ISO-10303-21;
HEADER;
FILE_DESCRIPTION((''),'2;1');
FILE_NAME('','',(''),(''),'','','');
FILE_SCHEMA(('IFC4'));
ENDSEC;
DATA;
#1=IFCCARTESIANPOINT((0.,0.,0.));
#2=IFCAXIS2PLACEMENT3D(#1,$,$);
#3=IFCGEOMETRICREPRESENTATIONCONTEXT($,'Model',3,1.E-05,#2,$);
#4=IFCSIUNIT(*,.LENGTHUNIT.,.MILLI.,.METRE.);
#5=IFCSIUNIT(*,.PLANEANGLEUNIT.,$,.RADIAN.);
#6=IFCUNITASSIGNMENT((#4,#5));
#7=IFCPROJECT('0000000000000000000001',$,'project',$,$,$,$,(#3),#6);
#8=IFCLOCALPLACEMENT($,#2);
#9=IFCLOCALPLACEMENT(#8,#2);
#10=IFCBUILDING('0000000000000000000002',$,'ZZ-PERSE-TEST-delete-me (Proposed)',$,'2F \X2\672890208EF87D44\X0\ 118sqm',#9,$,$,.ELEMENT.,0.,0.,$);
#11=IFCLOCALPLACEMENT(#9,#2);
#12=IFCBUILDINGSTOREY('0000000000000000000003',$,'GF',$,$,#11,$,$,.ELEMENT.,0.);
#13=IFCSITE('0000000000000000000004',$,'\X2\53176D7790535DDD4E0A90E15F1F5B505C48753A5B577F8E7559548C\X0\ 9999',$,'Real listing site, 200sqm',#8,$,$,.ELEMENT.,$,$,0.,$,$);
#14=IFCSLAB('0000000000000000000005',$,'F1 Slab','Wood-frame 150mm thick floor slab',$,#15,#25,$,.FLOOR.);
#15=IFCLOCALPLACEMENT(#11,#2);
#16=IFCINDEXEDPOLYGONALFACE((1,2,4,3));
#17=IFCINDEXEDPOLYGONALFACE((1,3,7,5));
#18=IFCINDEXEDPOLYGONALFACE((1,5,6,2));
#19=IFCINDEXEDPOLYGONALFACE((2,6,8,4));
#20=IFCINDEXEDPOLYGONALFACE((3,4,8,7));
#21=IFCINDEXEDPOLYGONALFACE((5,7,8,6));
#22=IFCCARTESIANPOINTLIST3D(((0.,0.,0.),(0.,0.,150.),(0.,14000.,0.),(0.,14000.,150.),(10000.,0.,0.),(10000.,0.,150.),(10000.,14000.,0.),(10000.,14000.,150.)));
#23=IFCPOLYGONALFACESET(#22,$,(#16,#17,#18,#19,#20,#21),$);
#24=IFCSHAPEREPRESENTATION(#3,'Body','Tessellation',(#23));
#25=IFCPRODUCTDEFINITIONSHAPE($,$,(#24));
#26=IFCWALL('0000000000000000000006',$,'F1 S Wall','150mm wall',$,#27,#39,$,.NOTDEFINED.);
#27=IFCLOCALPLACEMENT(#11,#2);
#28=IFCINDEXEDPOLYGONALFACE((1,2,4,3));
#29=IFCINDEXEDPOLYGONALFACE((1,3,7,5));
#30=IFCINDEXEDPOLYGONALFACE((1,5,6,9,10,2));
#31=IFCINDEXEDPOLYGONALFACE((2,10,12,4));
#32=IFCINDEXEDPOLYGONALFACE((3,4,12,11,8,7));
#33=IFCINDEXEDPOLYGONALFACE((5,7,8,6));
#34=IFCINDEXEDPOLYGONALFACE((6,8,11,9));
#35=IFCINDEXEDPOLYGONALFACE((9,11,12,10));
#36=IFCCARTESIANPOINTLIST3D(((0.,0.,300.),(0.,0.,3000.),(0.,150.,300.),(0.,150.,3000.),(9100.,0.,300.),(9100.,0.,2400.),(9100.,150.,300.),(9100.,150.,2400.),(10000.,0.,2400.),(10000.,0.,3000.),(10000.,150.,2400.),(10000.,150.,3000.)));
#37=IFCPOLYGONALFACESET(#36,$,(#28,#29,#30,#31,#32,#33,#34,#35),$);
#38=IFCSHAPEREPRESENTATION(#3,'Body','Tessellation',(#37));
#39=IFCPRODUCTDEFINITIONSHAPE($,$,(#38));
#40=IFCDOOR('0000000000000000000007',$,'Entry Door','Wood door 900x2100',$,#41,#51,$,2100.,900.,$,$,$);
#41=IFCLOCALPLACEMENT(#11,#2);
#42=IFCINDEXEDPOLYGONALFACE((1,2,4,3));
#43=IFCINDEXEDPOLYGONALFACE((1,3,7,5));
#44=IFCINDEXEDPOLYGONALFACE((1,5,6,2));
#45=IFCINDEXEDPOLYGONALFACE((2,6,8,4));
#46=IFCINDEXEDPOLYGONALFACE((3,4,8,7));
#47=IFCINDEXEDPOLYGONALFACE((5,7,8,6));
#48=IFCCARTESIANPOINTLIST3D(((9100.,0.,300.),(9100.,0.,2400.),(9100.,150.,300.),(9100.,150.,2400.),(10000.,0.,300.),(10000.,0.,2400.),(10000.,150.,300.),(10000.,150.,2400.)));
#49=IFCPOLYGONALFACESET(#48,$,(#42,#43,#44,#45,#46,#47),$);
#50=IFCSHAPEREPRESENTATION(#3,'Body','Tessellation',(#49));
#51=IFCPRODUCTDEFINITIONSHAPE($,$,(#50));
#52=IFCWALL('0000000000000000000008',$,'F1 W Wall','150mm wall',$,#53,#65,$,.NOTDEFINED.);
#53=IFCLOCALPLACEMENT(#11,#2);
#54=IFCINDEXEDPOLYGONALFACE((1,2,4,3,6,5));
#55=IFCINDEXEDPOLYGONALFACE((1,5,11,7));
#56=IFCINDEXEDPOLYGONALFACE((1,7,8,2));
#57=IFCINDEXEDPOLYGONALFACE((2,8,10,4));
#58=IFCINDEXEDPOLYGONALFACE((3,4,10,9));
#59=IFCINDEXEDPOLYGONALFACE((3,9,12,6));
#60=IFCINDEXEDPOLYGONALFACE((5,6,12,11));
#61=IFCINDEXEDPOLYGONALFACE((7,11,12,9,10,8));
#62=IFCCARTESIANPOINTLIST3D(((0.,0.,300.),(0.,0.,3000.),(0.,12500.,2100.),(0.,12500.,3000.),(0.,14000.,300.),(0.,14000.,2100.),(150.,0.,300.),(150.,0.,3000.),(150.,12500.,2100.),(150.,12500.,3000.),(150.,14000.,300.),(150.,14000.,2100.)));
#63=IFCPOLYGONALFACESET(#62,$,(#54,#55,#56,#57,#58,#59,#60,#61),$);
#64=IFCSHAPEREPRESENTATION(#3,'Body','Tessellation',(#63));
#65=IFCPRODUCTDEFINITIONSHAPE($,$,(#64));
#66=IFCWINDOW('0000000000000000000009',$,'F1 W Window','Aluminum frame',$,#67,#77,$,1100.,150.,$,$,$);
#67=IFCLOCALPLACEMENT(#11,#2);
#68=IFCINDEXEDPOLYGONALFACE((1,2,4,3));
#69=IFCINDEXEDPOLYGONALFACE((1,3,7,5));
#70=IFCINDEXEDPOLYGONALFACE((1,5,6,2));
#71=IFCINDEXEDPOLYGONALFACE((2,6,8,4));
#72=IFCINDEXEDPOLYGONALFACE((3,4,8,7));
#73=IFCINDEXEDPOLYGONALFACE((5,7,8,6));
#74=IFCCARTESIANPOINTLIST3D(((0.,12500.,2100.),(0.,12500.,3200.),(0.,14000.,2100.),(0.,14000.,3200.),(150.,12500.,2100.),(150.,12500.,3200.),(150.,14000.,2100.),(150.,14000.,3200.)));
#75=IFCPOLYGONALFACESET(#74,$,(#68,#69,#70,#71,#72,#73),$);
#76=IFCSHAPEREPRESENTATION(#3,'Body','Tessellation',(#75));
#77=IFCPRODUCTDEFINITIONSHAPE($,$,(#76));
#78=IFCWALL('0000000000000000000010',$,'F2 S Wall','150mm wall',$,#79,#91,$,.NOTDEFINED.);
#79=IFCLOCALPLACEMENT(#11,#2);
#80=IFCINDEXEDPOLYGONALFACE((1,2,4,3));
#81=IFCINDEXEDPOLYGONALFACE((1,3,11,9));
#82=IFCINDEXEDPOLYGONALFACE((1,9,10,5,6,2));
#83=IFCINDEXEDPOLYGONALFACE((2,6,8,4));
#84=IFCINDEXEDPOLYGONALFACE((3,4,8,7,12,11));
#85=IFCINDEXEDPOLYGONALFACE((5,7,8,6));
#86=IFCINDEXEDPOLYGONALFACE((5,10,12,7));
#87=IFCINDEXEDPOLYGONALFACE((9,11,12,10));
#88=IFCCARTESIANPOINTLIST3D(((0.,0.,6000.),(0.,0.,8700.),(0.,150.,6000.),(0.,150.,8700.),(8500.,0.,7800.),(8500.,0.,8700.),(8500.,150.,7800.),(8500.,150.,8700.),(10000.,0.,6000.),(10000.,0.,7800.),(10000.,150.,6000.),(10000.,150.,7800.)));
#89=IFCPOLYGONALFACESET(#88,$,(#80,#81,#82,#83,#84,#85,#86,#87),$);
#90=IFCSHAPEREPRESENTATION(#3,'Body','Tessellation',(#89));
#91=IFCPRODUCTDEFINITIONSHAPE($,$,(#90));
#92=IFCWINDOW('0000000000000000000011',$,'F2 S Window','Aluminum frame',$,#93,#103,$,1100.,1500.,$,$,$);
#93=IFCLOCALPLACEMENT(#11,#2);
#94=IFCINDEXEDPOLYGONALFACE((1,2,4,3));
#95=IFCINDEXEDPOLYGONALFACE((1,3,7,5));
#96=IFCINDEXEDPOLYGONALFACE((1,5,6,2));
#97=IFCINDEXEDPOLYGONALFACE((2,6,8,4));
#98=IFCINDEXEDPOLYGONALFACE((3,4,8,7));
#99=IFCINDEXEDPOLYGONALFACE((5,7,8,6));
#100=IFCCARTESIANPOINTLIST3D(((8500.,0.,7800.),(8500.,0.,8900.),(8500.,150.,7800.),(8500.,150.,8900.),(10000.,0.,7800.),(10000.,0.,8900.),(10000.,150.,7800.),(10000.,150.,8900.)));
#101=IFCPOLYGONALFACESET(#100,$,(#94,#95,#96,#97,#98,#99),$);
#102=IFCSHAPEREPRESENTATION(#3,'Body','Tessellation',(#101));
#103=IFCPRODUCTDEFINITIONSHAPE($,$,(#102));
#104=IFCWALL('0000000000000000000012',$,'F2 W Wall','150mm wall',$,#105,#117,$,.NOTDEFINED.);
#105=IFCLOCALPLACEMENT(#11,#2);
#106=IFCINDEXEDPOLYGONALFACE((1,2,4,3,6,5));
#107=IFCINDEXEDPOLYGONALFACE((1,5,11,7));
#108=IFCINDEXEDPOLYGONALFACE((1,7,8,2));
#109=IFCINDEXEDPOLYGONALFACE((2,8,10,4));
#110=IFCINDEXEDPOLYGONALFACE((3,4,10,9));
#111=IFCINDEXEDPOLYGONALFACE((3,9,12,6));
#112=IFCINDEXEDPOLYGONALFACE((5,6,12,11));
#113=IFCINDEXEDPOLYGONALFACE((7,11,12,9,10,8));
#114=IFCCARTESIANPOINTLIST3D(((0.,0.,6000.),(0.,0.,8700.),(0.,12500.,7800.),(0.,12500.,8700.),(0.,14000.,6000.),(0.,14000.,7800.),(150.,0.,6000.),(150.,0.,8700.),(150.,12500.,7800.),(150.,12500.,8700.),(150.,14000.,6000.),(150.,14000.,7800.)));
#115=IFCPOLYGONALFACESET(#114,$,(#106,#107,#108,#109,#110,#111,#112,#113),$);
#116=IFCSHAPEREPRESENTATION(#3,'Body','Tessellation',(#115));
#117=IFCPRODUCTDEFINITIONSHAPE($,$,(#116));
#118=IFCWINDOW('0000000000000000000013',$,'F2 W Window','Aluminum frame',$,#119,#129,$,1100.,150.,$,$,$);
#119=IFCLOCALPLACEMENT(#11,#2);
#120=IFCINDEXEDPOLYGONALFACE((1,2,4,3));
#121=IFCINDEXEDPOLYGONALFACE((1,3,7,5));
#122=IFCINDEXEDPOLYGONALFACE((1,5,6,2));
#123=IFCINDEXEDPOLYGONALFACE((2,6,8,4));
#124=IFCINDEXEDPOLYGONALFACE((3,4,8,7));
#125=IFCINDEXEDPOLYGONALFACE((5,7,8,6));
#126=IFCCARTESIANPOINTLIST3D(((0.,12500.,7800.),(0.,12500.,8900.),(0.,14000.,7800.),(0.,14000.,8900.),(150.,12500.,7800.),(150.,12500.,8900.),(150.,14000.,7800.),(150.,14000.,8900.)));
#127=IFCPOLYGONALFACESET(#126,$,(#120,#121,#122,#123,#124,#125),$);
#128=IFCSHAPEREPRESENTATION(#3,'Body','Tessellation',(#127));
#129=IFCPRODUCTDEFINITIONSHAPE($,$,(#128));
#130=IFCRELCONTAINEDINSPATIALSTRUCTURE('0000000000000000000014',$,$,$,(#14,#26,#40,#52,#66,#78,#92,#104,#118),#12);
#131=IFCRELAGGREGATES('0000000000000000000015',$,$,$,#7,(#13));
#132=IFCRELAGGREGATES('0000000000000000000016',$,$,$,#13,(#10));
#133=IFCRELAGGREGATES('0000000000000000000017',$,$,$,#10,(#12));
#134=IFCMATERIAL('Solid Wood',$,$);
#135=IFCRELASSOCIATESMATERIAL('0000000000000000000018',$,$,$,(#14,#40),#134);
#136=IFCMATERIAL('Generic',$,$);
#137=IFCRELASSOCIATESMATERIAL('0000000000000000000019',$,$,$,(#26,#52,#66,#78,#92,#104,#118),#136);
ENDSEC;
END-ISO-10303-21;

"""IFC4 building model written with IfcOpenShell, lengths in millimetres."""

from ifc_helpers import new_model, si_unit, frame, frame_2d, origin, place, context, project, spatial, rectangle, extrude, material, element, fill, save


model = new_model("IFC4")

# Units and contexts
model_context = context("Model", 3, precision=1e-05, world=origin())
ifc_project = project(units=[si_unit("LENGTHUNIT", "METRE", prefix="MILLI"), si_unit("PLANEANGLEUNIT", "RADIAN")], contexts=[model_context])

# Site, building, storey
site_placement = place(None, origin())
site = spatial("IfcSite", under=ifc_project, at=site_placement, Name="北海道川上郡弟子屈町字美留和 9999", ObjectType="Real listing site, 200sqm", CompositionType="ELEMENT", RefElevation=0.0)
building_placement = place(site_placement, origin())
building = spatial("IfcBuilding", under=site, at=building_placement, Name="ZZ-PERSE-TEST-delete-me (Proposed)", ObjectType="2F 木造軸組 118sqm", CompositionType="ELEMENT", ElevationOfRefHeight=0.0, ElevationOfTerrain=0.0)
storey_placement = place(building_placement, origin())
storey = spatial("IfcBuildingStorey", under=building, at=storey_placement, Name="GF", CompositionType="ELEMENT", Elevation=0.0)

# Slab
ifc_material_1 = material(Name="Solid Wood")
slab_1_placement = place(storey_placement, origin())
element("IfcSlab", 1, at=slab_1_placement, inside=storey, material=ifc_material_1, Name="F1 Slab", Description="Wood-frame 150mm thick floor slab", PredefinedType="FLOOR", context=model_context, shape_type="SweptSolid", body=[
    extrude(rectangle(XDim=10000.0, YDim=14000.0, at=frame_2d((5000.0, 7000.0))), origin(), (0.0, 0.0, 1.0), 150.0),
])

# Shared definitions
ifc_material_2 = material(Name="Generic")

# Wall, opening, door
wall_1_placement = place(storey_placement, frame((0.0, 0.0, 150.0)))
wall_1 = element("IfcWall", 2, at=wall_1_placement, inside=storey, material=ifc_material_2, Name="F1 S Wall", Description="150mm wall", PredefinedType="NOTDEFINED", context=model_context, shape_type="SweptSolid", body=[
    extrude(rectangle(XDim=10000.0, YDim=150.0, at=frame_2d((5000.0, 75.0))), frame((0.0, 0.0, 150.0)), (0.0, 0.0, 1.0), 2700.0),
])
opening_1_placement = place(storey_placement, frame((4550.0, 0.0, 150.0)))
opening_1 = element("IfcOpeningElement", 3, at=opening_1_placement, cuts=wall_1, PredefinedType="NOTDEFINED", context=model_context, shape_type="SweptSolid", body=[
    extrude(rectangle(XDim=900.0, YDim=150.0, at=frame_2d((450.0, 75.0))), frame((4550.0, 0.0, 150.0)), (0.0, 0.0, 1.0), 2100.0),
])
door_placement = place(storey_placement, frame((4550.0, 0.0, 150.0)))
door = element("IfcDoor", 4, at=door_placement, inside=storey, material=ifc_material_1, Name="Entry Door", Description="Wood door 900x2100", OverallHeight=2100.0, OverallWidth=900.0, context=model_context, shape_type="SweptSolid", body=[
    extrude(rectangle(XDim=900.0, YDim=150.0, at=frame_2d((450.0, 75.0))), frame((4550.0, 0.0, 150.0)), (0.0, 0.0, 1.0), 2100.0),
])
fill(opening_1, door)

# Walls, openings, windows
wall_2_placement = place(storey_placement, frame((0.0, 0.0, 150.0)))
wall_2 = element("IfcWall", 5, at=wall_2_placement, inside=storey, material=ifc_material_2, Name="F1 W Wall", Description="150mm wall", PredefinedType="NOTDEFINED", context=model_context, shape_type="SweptSolid", body=[
    extrude(rectangle(XDim=150.0, YDim=14000.0, at=frame_2d((75.0, 7000.0))), frame((0.0, 0.0, 150.0)), (0.0, 0.0, 1.0), 2700.0),
])
opening_2_placement = place(storey_placement, frame((0.0, 6250.0, 1050.0)))
opening_2 = element("IfcOpeningElement", 6, at=opening_2_placement, cuts=wall_2, PredefinedType="NOTDEFINED", context=model_context, shape_type="SweptSolid", body=[
    extrude(rectangle(XDim=150.0, YDim=1500.0, at=frame_2d((75.0, 750.0))), frame((0.0, 6250.0, 1050.0)), (0.0, 0.0, 1.0), 1100.0),
])
window_1_placement = place(storey_placement, frame((0.0, 6250.0, 1050.0)))
window_1 = element("IfcWindow", 7, at=window_1_placement, inside=storey, material=ifc_material_2, Name="F1 W Window", Description="Aluminum frame", OverallHeight=1100.0, OverallWidth=150.0, context=model_context, shape_type="SweptSolid", body=[
    extrude(rectangle(XDim=150.0, YDim=1500.0, at=frame_2d((75.0, 750.0))), frame((0.0, 6250.0, 1050.0)), (0.0, 0.0, 1.0), 1100.0),
])
fill(opening_2, window_1)
wall_3_placement = place(storey_placement, frame((0.0, 0.0, 3000.0)))
wall_3 = element("IfcWall", 8, at=wall_3_placement, inside=storey, material=ifc_material_2, Name="F2 S Wall", Description="150mm wall", PredefinedType="NOTDEFINED", context=model_context, shape_type="SweptSolid", body=[
    extrude(rectangle(XDim=10000.0, YDim=150.0, at=frame_2d((5000.0, 75.0))), frame((0.0, 0.0, 3000.0)), (0.0, 0.0, 1.0), 2700.0),
])
opening_3_placement = place(storey_placement, frame((4250.0, 0.0, 3900.0)))
opening_3 = element("IfcOpeningElement", 9, at=opening_3_placement, cuts=wall_3, PredefinedType="NOTDEFINED", context=model_context, shape_type="SweptSolid", body=[
    extrude(rectangle(XDim=1500.0, YDim=150.0, at=frame_2d((750.0, 75.0))), frame((4250.0, 0.0, 3900.0)), (0.0, 0.0, 1.0), 1100.0),
])
window_2_placement = place(storey_placement, frame((4250.0, 0.0, 3900.0)))
window_2 = element("IfcWindow", 10, at=window_2_placement, inside=storey, material=ifc_material_2, Name="F2 S Window", Description="Aluminum frame", OverallHeight=1100.0, OverallWidth=1500.0, context=model_context, shape_type="SweptSolid", body=[
    extrude(rectangle(XDim=1500.0, YDim=150.0, at=frame_2d((750.0, 75.0))), frame((4250.0, 0.0, 3900.0)), (0.0, 0.0, 1.0), 1100.0),
])
fill(opening_3, window_2)
wall_4_placement = place(storey_placement, frame((0.0, 0.0, 3000.0)))
wall_4 = element("IfcWall", 11, at=wall_4_placement, inside=storey, material=ifc_material_2, Name="F2 W Wall", Description="150mm wall", PredefinedType="NOTDEFINED", context=model_context, shape_type="SweptSolid", body=[
    extrude(rectangle(XDim=150.0, YDim=14000.0, at=frame_2d((75.0, 7000.0))), frame((0.0, 0.0, 3000.0)), (0.0, 0.0, 1.0), 2700.0),
])
opening_4_placement = place(storey_placement, frame((0.0, 6250.0, 3900.0)))
opening_4 = element("IfcOpeningElement", 12, at=opening_4_placement, cuts=wall_4, PredefinedType="NOTDEFINED", context=model_context, shape_type="SweptSolid", body=[
    extrude(rectangle(XDim=150.0, YDim=1500.0, at=frame_2d((75.0, 750.0))), frame((0.0, 6250.0, 3900.0)), (0.0, 0.0, 1.0), 1100.0),
])
window_3_placement = place(storey_placement, frame((0.0, 6250.0, 3900.0)))
window_3 = element("IfcWindow", 13, at=window_3_placement, inside=storey, material=ifc_material_2, Name="F2 W Window", Description="Aluminum frame", OverallHeight=1100.0, OverallWidth=150.0, context=model_context, shape_type="SweptSolid", body=[
    extrude(rectangle(XDim=150.0, YDim=1500.0, at=frame_2d((75.0, 750.0))), frame((0.0, 6250.0, 3900.0)), (0.0, 0.0, 1.0), 1100.0),
])
fill(opening_4, window_3)

save(model, "model.ifc")
